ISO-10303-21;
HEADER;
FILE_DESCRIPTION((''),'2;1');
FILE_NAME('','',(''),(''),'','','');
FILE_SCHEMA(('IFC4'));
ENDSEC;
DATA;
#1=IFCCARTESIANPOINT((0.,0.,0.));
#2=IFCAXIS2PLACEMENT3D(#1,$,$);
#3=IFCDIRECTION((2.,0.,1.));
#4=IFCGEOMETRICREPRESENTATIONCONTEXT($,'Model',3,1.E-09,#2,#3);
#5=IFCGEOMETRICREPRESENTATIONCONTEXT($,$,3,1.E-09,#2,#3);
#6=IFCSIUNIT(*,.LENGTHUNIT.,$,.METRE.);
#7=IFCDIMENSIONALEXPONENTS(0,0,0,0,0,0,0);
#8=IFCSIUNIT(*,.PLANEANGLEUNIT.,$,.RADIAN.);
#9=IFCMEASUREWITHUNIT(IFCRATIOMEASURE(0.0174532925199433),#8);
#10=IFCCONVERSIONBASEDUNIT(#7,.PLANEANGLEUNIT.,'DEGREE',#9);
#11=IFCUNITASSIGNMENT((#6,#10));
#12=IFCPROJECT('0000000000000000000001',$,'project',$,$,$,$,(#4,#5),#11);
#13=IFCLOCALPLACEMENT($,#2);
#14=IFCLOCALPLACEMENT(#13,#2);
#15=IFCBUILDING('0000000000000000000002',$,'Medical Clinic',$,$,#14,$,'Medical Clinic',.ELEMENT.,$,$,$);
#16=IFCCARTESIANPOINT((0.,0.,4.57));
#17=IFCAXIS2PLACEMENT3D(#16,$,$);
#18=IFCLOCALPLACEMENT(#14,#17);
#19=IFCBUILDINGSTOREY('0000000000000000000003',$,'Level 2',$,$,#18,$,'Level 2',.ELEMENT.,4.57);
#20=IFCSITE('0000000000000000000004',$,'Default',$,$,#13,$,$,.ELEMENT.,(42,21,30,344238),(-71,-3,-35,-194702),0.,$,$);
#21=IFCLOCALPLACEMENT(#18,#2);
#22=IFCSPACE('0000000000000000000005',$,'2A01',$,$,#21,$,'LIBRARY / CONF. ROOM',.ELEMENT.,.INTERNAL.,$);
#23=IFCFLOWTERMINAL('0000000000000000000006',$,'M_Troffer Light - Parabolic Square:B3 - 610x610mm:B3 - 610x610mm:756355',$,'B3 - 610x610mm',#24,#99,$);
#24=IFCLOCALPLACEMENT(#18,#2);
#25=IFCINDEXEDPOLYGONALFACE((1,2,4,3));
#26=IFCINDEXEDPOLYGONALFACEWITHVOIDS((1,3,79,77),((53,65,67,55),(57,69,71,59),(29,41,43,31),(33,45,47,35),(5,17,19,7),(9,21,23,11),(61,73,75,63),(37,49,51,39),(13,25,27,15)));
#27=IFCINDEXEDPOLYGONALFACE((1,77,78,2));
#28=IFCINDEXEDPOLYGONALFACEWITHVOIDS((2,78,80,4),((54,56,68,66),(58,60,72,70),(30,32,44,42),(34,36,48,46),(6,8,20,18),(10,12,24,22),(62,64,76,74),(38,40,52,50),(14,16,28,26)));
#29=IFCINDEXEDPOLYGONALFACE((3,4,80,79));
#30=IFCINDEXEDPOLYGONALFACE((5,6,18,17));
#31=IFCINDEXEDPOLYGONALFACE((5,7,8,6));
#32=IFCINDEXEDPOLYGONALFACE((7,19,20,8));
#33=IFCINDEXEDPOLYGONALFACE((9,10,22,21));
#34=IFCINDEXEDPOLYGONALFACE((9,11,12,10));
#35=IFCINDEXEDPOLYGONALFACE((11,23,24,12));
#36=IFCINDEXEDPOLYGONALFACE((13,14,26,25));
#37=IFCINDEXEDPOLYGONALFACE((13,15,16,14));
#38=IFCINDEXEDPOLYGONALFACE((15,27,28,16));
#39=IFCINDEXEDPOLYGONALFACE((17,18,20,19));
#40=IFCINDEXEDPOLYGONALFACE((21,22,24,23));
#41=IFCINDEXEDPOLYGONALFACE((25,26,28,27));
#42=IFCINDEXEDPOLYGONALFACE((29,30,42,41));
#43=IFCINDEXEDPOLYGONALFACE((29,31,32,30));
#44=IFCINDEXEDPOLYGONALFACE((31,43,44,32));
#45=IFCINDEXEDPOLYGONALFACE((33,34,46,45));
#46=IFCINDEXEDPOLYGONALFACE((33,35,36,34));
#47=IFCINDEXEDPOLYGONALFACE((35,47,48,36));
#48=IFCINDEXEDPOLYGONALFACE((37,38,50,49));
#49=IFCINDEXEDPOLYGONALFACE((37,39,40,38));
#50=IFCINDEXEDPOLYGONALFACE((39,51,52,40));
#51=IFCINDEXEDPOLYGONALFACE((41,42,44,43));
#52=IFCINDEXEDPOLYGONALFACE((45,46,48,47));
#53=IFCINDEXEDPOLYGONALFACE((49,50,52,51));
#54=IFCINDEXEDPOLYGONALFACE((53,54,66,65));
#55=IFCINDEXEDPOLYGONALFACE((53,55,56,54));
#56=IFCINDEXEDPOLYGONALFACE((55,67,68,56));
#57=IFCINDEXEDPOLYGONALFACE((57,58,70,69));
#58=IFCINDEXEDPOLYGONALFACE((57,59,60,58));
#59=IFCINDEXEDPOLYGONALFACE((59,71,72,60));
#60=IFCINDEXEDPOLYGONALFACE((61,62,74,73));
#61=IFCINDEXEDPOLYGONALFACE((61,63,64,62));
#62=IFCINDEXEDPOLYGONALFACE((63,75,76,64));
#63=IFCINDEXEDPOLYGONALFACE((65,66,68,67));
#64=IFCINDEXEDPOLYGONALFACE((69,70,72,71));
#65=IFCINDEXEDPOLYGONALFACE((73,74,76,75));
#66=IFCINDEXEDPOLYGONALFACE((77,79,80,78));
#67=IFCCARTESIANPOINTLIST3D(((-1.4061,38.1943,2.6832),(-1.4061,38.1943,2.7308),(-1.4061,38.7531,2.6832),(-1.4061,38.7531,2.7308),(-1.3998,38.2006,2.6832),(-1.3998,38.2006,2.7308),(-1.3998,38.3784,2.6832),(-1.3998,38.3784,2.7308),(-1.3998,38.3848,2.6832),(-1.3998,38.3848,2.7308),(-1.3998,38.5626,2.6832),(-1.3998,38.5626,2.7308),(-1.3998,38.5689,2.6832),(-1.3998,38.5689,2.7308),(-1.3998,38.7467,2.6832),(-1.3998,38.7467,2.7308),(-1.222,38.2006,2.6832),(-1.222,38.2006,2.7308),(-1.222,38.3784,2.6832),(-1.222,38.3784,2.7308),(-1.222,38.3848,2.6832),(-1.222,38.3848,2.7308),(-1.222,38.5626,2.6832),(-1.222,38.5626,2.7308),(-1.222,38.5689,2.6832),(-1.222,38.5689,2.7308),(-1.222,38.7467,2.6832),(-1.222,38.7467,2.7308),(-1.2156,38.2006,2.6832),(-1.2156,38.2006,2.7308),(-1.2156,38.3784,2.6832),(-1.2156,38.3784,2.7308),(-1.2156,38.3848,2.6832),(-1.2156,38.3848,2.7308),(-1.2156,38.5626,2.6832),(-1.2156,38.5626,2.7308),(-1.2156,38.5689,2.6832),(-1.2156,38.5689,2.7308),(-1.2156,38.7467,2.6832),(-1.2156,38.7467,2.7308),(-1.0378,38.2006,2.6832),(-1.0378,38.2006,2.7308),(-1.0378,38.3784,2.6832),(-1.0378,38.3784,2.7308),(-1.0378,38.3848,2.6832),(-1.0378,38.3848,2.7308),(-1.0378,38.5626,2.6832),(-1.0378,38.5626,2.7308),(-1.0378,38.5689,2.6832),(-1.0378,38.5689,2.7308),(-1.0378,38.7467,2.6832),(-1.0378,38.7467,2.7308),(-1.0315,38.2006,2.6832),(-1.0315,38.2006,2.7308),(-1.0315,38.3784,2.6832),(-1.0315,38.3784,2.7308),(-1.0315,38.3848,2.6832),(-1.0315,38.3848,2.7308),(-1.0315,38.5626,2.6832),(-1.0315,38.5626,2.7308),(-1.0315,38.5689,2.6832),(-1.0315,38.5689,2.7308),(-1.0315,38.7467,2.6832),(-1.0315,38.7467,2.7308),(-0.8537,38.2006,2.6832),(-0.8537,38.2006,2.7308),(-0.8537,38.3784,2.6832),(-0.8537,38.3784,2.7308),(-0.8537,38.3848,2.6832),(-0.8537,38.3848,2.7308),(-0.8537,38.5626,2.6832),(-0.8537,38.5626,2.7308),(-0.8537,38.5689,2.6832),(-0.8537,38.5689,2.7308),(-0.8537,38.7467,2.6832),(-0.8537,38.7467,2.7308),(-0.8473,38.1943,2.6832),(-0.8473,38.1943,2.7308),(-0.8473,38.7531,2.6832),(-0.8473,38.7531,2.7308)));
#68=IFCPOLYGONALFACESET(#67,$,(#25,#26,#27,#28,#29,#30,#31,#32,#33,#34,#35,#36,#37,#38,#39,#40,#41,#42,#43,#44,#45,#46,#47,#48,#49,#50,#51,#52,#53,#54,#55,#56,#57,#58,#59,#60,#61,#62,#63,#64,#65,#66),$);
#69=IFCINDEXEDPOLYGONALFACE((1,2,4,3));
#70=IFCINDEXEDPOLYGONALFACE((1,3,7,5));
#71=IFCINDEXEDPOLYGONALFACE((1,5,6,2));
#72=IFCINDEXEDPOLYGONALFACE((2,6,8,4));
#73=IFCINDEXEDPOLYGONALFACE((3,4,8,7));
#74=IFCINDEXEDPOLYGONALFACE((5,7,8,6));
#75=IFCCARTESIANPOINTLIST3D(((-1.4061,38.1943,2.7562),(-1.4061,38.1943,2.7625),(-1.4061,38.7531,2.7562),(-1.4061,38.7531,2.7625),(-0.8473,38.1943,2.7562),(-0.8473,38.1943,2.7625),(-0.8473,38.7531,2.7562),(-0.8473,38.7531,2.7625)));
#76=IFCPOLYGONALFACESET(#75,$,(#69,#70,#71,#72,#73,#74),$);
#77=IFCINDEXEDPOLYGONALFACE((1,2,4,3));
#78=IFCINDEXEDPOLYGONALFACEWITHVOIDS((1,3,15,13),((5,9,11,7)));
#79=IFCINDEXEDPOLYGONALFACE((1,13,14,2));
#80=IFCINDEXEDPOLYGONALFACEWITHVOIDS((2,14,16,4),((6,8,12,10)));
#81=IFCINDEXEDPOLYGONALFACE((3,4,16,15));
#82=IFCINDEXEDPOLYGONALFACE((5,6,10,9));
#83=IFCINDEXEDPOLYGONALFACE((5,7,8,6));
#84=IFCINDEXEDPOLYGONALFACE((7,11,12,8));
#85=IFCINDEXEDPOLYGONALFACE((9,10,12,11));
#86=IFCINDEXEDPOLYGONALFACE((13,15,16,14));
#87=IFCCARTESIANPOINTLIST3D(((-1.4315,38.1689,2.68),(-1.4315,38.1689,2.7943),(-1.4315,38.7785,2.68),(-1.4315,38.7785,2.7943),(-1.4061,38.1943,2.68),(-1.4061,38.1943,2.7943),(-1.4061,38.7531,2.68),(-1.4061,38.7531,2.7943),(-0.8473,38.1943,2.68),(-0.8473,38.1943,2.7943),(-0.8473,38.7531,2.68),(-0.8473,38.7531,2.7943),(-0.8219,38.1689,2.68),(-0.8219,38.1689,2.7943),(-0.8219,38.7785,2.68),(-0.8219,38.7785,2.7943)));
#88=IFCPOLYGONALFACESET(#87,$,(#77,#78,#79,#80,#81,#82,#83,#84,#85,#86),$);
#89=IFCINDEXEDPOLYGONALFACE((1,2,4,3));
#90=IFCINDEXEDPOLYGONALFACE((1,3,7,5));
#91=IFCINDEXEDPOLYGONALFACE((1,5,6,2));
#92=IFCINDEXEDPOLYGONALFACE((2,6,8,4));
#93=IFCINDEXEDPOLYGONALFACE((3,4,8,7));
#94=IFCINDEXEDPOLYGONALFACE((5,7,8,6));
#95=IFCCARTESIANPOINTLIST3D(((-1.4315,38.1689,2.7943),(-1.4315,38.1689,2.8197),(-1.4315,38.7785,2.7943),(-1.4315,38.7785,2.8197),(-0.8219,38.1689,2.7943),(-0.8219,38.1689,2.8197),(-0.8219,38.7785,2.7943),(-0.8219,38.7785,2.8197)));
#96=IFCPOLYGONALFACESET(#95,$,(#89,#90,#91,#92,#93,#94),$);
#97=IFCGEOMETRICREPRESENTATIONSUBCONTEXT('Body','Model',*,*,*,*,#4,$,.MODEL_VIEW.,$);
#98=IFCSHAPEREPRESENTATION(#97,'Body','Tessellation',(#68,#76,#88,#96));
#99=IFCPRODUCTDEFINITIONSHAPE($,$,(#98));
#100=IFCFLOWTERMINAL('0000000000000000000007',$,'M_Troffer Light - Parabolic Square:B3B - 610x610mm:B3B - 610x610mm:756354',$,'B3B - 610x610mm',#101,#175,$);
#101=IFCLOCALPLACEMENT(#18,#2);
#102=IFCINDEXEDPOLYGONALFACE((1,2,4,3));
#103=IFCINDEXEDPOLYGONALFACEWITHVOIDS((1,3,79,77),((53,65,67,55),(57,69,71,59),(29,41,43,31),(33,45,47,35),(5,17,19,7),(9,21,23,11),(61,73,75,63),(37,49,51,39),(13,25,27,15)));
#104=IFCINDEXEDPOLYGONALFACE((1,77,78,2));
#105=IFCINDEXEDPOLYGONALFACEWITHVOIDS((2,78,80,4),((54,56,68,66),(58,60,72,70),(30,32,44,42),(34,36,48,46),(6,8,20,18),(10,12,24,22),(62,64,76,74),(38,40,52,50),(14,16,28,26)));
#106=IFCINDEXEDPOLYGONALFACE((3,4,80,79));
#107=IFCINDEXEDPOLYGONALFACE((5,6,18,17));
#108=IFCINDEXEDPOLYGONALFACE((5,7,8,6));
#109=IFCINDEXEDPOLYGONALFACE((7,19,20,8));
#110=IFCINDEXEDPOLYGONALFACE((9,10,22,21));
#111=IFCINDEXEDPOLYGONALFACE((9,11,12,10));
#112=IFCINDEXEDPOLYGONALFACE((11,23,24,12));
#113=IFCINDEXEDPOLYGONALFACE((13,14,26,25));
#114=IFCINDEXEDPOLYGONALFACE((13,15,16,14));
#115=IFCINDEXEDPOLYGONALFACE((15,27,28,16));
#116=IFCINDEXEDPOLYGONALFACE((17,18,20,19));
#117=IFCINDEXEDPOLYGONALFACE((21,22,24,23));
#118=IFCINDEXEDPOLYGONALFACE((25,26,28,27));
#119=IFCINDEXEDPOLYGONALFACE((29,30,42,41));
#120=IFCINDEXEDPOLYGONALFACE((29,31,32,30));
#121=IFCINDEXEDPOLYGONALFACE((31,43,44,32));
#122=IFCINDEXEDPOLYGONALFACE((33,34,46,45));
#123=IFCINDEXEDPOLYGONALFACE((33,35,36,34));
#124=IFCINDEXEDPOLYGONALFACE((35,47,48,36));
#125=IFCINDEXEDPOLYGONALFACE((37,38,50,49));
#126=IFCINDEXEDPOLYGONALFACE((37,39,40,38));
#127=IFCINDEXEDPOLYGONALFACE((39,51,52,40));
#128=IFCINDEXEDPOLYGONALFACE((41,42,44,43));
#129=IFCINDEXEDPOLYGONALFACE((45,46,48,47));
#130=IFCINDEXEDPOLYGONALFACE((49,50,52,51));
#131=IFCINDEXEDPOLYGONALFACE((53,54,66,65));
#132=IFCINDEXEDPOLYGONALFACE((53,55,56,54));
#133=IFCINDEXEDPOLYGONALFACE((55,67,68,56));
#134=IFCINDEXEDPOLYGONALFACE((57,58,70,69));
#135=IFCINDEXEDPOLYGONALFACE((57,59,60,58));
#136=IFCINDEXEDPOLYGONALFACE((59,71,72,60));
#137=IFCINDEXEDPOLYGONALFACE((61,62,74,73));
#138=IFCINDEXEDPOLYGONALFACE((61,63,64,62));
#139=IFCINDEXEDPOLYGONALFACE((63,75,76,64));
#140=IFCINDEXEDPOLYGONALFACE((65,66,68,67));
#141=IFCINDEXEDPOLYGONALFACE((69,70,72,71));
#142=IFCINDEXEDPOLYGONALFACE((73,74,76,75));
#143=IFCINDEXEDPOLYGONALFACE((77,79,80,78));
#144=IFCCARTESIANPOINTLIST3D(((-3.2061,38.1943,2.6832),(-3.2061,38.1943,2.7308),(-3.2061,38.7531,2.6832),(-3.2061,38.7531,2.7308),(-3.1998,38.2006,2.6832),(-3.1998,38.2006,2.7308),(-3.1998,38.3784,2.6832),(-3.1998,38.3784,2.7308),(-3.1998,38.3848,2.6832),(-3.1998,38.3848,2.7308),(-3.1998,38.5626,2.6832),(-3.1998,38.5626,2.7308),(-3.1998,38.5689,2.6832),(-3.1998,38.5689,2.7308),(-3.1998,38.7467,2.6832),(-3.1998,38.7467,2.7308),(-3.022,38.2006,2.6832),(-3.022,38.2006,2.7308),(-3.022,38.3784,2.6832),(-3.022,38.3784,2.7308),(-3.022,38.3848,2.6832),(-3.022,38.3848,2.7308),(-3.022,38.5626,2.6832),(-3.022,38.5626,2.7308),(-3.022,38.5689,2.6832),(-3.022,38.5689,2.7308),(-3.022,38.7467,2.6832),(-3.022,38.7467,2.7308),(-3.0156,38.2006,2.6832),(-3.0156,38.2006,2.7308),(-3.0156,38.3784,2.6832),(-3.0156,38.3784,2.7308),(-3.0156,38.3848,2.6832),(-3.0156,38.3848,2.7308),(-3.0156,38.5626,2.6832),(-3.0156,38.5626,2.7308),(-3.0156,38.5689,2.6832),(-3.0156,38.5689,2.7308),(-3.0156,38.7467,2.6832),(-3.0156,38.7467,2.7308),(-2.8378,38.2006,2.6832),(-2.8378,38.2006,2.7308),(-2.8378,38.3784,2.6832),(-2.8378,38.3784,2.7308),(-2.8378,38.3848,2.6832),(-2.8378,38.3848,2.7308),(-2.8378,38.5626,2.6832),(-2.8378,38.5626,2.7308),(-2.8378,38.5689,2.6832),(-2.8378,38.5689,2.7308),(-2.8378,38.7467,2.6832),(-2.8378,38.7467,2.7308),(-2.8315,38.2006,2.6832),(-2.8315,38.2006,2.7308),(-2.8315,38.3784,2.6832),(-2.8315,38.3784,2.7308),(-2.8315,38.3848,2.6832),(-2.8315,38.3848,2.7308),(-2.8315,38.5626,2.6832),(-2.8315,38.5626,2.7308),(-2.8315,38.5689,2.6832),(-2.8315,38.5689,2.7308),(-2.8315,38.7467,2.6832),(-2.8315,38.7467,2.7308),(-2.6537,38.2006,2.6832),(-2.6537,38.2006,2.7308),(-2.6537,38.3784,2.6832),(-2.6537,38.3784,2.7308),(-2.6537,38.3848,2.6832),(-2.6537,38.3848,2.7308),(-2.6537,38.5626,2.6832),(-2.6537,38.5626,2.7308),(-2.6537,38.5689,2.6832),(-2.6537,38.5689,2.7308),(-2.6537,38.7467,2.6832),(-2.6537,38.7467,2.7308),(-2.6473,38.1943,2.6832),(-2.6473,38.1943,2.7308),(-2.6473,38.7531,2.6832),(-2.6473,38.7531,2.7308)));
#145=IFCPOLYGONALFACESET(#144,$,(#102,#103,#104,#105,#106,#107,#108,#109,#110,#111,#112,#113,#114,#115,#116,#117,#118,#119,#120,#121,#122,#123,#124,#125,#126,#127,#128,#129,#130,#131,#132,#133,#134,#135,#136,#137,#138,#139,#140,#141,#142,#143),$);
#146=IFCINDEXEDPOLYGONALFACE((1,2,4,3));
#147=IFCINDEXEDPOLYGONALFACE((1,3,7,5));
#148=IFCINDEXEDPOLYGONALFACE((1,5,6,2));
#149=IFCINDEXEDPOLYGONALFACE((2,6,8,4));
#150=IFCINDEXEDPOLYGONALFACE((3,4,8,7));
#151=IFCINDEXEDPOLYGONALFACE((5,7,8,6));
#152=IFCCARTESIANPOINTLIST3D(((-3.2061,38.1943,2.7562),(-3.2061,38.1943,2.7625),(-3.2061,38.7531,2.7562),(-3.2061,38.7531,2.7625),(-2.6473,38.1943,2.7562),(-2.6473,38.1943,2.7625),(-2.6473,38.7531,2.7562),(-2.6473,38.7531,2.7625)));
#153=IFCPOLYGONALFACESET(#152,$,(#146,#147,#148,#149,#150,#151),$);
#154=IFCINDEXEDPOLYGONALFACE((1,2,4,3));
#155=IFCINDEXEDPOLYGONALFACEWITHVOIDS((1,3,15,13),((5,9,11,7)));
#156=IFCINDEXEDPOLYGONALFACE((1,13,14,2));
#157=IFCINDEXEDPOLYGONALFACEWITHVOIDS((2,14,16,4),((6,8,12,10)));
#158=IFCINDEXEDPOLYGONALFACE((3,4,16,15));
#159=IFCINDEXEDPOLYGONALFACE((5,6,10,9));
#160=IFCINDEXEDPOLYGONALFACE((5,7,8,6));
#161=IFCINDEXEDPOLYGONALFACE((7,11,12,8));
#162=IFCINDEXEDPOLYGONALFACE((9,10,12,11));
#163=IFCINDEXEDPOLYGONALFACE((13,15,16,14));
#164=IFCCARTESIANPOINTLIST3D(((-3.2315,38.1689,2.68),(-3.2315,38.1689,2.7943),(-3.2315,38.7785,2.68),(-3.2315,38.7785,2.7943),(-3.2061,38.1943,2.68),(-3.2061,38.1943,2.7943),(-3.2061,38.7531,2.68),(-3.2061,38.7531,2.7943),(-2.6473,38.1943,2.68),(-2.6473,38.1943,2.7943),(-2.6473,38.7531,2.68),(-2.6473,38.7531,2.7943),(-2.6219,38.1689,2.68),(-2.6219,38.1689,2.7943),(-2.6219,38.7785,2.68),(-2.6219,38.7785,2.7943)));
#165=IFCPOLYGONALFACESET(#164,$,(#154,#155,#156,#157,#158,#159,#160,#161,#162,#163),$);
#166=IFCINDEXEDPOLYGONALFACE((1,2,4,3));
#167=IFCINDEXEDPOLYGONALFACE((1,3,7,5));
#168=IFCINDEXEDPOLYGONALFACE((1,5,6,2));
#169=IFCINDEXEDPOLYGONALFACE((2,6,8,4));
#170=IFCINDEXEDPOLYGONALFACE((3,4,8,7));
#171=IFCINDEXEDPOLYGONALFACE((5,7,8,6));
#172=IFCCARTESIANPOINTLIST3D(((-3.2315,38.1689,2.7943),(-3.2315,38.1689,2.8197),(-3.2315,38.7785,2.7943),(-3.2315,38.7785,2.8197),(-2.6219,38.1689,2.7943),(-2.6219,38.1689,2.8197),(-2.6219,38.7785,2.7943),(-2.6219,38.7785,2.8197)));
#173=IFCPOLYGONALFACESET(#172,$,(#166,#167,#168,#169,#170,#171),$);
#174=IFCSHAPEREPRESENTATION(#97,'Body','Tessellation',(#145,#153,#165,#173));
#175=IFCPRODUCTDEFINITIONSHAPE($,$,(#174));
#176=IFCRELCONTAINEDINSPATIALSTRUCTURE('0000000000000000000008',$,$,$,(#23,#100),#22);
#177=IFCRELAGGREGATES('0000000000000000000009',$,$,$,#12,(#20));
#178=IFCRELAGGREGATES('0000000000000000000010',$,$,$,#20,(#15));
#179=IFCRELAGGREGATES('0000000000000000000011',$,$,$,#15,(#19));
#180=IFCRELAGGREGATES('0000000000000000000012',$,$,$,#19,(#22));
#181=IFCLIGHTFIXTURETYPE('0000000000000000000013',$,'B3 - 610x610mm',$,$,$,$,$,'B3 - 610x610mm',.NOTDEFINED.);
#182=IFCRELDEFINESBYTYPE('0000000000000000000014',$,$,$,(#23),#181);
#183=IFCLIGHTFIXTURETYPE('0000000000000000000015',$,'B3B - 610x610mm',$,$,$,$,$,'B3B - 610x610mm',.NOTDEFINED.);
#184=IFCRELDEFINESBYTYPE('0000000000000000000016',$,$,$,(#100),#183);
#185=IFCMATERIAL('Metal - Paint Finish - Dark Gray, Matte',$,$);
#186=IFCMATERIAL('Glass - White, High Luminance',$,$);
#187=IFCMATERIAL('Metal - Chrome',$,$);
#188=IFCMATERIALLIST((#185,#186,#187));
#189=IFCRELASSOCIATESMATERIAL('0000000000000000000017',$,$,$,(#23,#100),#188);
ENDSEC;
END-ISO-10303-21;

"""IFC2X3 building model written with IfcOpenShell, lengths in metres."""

from ifc_helpers import new_model, entity, si_unit, converted_unit, direction, frame, origin, origin_2d_with_axis, place, context, subcontext, project, spatial, polyline, rectangle, outline, extrude, source, transform, mapped, material, material_list, type_object, type_shapes, element, save


model = new_model("IFC2X3")

# Units and contexts
model_context = context("Model", 3, precision=1e-09, world=origin(), true_north=direction((2.0, 0.0, 1.0)))
context_of_model = context(None, 3, precision=1e-09, world=origin(), true_north=direction((2.0, 0.0, 1.0)))
body_context = subcontext(model_context, "Body", "Model", "MODEL_VIEW")
ifc_project = project(units=[si_unit("LENGTHUNIT", "METRE"), converted_unit("PLANEANGLEUNIT", "DEGREE", entity("IfcRatioMeasure", 0.0174532925199433), si_unit("PLANEANGLEUNIT", "RADIAN"), dimensions=[0, 0, 0, 0, 0, 0, 0])], contexts=[model_context, context_of_model])

# Site, building, storey
site_placement = place(None, origin())
site = spatial("IfcSite", under=ifc_project, at=site_placement, Name="Default", CompositionType="ELEMENT", RefLatitude=(42, 21, 30, 344238), RefLongitude=(-71, -3, -35, -194702), RefElevation=0.0)
building_placement = place(site_placement, origin())
building = spatial("IfcBuilding", under=site, at=building_placement, Name="Medical Clinic", LongName="Medical Clinic", CompositionType="ELEMENT")
storey_placement = place(building_placement, frame((0.0, 0.0, 4.57)))
storey = spatial("IfcBuildingStorey", under=building, at=storey_placement, Name="Level 2", LongName="Level 2", CompositionType="ELEMENT", Elevation=4.57)

# Shared definitions
space_1_placement = place(storey_placement, origin())
space_1 = spatial("IfcSpace", under=storey, at=space_1_placement, Name="2A01", LongName="LIBRARY / CONF. ROOM", CompositionType="ELEMENT", InteriorOrExteriorSpace="INTERNAL")

# Flow terminals
ifc_material_1 = material(Name="Metal - Paint Finish - Dark Gray, Matte")
ifc_material_2 = material(Name="Glass - White, High Luminance")
ifc_material_3 = material(Name="Metal - Chrome")
ifc_material_list = material_list([ifc_material_1, ifc_material_2, ifc_material_3])
light_fixture_type_1 = type_object("IfcLightFixtureType", Name="B3 - 610x610mm", ElementType="B3 - 610x610mm", PredefinedType="NOTDEFINED")
shared_shape_1 = source(origin(), body_context, "Body", "SweptSolid", [
    extrude(outline(polyline([(-0.2794, -0.2794), (0.2794, -0.2794), (0.2794, 0.2794), (-0.2794, 0.2794), (-0.2794, -0.2794)]), holes=[polyline([(-0.0952, 0.0953), (-0.273, 0.0953), (-0.273, 0.2731), (-0.0952, 0.2731), (-0.0952, 0.0953)]), polyline([(0.2731, 0.0953), (0.0953, 0.0953), (0.0953, 0.2731), (0.2731, 0.2731), (0.2731, 0.0953)]), polyline([(-0.0889, 0.2731), (0.0889, 0.2731), (0.0889, 0.0953), (-0.0889, 0.0953), (-0.0889, 0.2731)]), polyline([(0.2731, -0.273), (0.0953, -0.273), (0.0953, -0.0952), (0.2731, -0.0952), (0.2731, -0.273)]), polyline([(0.0889, -0.273), (-0.0889, -0.273), (-0.0889, -0.0952), (0.0889, -0.0952), (0.0889, -0.273)]), polyline([(-0.0952, -0.273), (-0.273, -0.273), (-0.273, -0.0952), (-0.0952, -0.0952), (-0.0952, -0.273)]), polyline([(-0.0952, -0.0889), (-0.273, -0.0889), (-0.273, 0.0889), (-0.0952, 0.0889), (-0.0952, -0.0889)]), polyline([(0.0889, -0.0889), (-0.0889, -0.0889), (-0.0889, 0.0889), (0.0889, 0.0889), (0.0889, -0.0889)]), polyline([(0.2731, -0.0889), (0.0953, -0.0889), (0.0953, 0.0889), (0.2731, 0.0889), (0.2731, -0.0889)])]), frame((0.0, -0.3048, -0.0508), z_axis=(0.0, 0.0, 1.0), x_axis=(-1.0, 0.0, 0.0)), (0.0, 0.0, 1.0), 0.0476),
    extrude(rectangle(XDim=0.5588, YDim=0.5588, at=origin_2d_with_axis()), frame((0.0, -0.3048, -0.0825), z_axis=(0.0, 0.0, 1.0), x_axis=(-1.0, 0.0, 0.0)), (0.0, 0.0, 1.0), 0.0064),
    extrude(outline(polyline([(-0.3048, -0.3048), (0.3048, -0.3048), (0.3048, 0.3048), (-0.3048, 0.3048), (-0.3048, -0.3048)]), holes=[polyline([(0.2794, 0.2794), (0.2794, -0.2794), (-0.2794, -0.2794), (-0.2794, 0.2794), (0.2794, 0.2794)])]), frame((0.0, -0.3048, -0.1143)), (0.0, 0.0, 1.0), 0.1143),
    extrude(rectangle(XDim=0.6096, YDim=0.6096, at=origin_2d_with_axis()), frame((0.0, -0.3048, -0.1397), z_axis=(0.0, 0.0, 1.0), x_axis=(-1.0, 0.0, 0.0)), (0.0, 0.0, 1.0), 0.0254),
])
type_shapes(light_fixture_type_1, [shared_shape_1])
for number, where, z_axis, x_axis, name in (
    (1, (-1.1267, 38.1689, 2.68), (0.0, 0.0, -1.0), (1.0, 0.0, 0.0), "M_Troffer Light - Parabolic Square:B3 - 610x610mm:B3 - 610x610mm:756355"),
):
    element("IfcFlowTerminal", number, at=place(space_1_placement, frame(where, z_axis=z_axis, x_axis=x_axis)), inside=space_1, type_object=light_fixture_type_1, material=ifc_material_list, Name=name, ObjectType="B3 - 610x610mm", context=body_context, shape_type="MappedRepresentation", body=[
        mapped(shared_shape_1, transform((0.0, 0.0, 0.0), scale=1.0)),
    ])
light_fixture_type_2 = type_object("IfcLightFixtureType", Name="B3B - 610x610mm", ElementType="B3B - 610x610mm", PredefinedType="NOTDEFINED")
shared_shape_2 = source(origin(), body_context, "Body", "SweptSolid", [
    extrude(outline(polyline([(-0.2794, -0.2794), (0.2794, -0.2794), (0.2794, 0.2794), (-0.2794, 0.2794), (-0.2794, -0.2794)]), holes=[polyline([(-0.0952, 0.0953), (-0.273, 0.0953), (-0.273, 0.2731), (-0.0952, 0.2731), (-0.0952, 0.0953)]), polyline([(0.2731, 0.0953), (0.0953, 0.0953), (0.0953, 0.2731), (0.2731, 0.2731), (0.2731, 0.0953)]), polyline([(-0.0889, 0.2731), (0.0889, 0.2731), (0.0889, 0.0953), (-0.0889, 0.0953), (-0.0889, 0.2731)]), polyline([(0.2731, -0.273), (0.0953, -0.273), (0.0953, -0.0952), (0.2731, -0.0952), (0.2731, -0.273)]), polyline([(0.0889, -0.273), (-0.0889, -0.273), (-0.0889, -0.0952), (0.0889, -0.0952), (0.0889, -0.273)]), polyline([(-0.0952, -0.273), (-0.273, -0.273), (-0.273, -0.0952), (-0.0952, -0.0952), (-0.0952, -0.273)]), polyline([(-0.0952, -0.0889), (-0.273, -0.0889), (-0.273, 0.0889), (-0.0952, 0.0889), (-0.0952, -0.0889)]), polyline([(0.0889, -0.0889), (-0.0889, -0.0889), (-0.0889, 0.0889), (0.0889, 0.0889), (0.0889, -0.0889)]), polyline([(0.2731, -0.0889), (0.0953, -0.0889), (0.0953, 0.0889), (0.2731, 0.0889), (0.2731, -0.0889)])]), frame((0.0, -0.3048, -0.0508), z_axis=(0.0, 0.0, 1.0), x_axis=(-1.0, 0.0, 0.0)), (0.0, 0.0, 1.0), 0.0476),
    extrude(rectangle(XDim=0.5588, YDim=0.5588, at=origin_2d_with_axis()), frame((0.0, -0.3048, -0.0825), z_axis=(0.0, 0.0, 1.0), x_axis=(-1.0, 0.0, 0.0)), (0.0, 0.0, 1.0), 0.0064),
    extrude(outline(polyline([(-0.3048, -0.3048), (0.3048, -0.3048), (0.3048, 0.3048), (-0.3048, 0.3048), (-0.3048, -0.3048)]), holes=[polyline([(0.2794, 0.2794), (0.2794, -0.2794), (-0.2794, -0.2794), (-0.2794, 0.2794), (0.2794, 0.2794)])]), frame((0.0, -0.3048, -0.1143)), (0.0, 0.0, 1.0), 0.1143),
    extrude(rectangle(XDim=0.6096, YDim=0.6096, at=origin_2d_with_axis()), frame((0.0, -0.3048, -0.1397), z_axis=(0.0, 0.0, 1.0), x_axis=(-1.0, 0.0, 0.0)), (0.0, 0.0, 1.0), 0.0254),
])
type_shapes(light_fixture_type_2, [shared_shape_2])
flow_terminal_1_placement = place(space_1_placement, frame((-2.9267, 38.1689, 2.68), z_axis=(0.0, 0.0, -1.0), x_axis=(1.0, 0.0, 0.0)))
element("IfcFlowTerminal", 2, at=flow_terminal_1_placement, inside=space_1, type_object=light_fixture_type_2, material=ifc_material_list, Name="M_Troffer Light - Parabolic Square:B3B - 610x610mm:B3B - 610x610mm:756354", ObjectType="B3B - 610x610mm", context=body_context, shape_type="MappedRepresentation", body=[
    mapped(shared_shape_2, transform((0.0, 0.0, 0.0), scale=1.0)),
])

save(model, "model.ifc")
